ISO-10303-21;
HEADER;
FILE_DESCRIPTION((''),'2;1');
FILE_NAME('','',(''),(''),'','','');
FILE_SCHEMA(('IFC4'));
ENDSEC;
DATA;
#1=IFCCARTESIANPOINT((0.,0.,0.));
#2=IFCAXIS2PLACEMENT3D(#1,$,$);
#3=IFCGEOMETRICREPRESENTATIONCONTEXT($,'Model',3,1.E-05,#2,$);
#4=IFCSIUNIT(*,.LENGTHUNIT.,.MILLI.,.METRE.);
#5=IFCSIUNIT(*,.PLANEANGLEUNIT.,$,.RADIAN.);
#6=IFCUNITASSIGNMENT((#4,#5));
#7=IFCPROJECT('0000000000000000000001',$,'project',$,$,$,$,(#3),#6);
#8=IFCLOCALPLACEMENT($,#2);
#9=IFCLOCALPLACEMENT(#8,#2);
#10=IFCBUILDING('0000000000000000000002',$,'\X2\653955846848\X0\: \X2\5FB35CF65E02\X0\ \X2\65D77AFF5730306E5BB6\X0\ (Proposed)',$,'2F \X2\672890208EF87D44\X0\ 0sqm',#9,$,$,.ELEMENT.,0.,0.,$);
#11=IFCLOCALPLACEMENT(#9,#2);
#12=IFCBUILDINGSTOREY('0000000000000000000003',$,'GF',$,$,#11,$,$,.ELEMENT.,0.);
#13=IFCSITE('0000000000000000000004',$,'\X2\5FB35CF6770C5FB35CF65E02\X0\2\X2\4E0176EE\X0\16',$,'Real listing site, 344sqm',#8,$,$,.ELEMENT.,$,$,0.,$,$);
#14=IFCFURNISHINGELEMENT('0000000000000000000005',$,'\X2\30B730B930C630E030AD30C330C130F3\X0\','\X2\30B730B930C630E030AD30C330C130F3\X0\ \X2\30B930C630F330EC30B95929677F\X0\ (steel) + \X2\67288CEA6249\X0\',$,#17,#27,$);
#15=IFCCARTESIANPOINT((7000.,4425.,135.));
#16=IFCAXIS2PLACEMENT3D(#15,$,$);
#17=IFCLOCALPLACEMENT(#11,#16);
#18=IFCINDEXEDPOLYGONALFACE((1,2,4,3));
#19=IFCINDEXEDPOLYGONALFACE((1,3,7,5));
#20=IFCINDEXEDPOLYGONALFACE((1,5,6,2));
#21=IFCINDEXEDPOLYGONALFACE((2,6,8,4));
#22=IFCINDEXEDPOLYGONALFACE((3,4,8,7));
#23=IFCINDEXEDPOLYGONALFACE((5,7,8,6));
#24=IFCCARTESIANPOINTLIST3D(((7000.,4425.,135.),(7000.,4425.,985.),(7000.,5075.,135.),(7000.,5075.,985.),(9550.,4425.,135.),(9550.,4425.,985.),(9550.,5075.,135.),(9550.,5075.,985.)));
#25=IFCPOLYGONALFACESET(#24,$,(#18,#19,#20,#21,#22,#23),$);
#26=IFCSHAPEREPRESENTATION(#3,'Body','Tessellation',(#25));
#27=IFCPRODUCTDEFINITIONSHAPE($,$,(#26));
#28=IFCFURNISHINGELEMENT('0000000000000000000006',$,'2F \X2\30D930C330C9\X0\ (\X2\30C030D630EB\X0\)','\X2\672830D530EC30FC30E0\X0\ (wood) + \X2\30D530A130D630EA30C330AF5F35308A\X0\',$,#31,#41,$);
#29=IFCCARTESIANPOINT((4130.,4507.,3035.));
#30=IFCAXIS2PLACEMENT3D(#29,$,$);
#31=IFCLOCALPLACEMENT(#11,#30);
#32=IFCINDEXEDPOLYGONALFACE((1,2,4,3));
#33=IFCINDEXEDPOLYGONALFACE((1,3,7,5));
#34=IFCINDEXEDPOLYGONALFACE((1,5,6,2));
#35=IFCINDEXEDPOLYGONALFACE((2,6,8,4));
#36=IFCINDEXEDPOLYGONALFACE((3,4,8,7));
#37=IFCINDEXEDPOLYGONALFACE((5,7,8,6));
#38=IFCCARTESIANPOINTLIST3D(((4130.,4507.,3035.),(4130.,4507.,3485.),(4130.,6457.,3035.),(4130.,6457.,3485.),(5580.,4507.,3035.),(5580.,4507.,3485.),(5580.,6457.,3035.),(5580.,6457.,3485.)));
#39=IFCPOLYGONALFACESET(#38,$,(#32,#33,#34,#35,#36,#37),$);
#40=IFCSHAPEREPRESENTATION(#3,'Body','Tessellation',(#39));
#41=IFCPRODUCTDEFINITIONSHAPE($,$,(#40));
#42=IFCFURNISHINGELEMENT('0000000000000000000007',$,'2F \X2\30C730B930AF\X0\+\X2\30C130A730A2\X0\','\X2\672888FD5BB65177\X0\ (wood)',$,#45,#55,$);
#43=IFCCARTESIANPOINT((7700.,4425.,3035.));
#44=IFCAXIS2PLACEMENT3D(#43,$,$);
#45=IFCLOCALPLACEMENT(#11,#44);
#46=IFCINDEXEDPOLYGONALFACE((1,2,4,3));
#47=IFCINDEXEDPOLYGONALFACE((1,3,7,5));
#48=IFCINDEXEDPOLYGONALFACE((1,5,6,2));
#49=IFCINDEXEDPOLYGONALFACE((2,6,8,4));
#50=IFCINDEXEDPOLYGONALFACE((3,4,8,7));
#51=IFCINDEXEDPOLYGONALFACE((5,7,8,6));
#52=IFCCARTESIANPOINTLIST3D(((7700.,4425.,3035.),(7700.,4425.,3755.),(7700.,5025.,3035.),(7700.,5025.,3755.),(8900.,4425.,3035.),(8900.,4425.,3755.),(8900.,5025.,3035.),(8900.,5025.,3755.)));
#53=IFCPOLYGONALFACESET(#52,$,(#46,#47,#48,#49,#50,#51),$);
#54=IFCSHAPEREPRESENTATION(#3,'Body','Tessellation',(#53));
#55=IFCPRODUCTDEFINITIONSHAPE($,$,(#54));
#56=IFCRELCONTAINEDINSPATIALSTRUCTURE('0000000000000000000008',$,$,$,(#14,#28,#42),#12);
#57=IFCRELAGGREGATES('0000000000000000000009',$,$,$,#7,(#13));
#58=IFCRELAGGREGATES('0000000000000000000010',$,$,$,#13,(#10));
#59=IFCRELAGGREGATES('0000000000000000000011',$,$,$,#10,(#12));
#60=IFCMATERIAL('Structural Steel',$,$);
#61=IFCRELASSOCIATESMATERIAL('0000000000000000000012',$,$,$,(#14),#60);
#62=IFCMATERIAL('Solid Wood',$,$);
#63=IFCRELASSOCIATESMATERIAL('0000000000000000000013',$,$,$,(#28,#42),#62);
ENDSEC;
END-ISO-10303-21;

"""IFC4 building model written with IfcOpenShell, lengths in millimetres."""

from ifc_helpers import new_model, si_unit, frame, frame_2d, origin, place, context, project, spatial, rectangle, extrude, material, element, save


model = new_model("IFC4")

# Units and contexts
model_context = context("Model", 3, precision=1e-05, world=origin())
ifc_project = project(units=[si_unit("LENGTHUNIT", "METRE", prefix="MILLI"), si_unit("PLANEANGLEUNIT", "RADIAN")], contexts=[model_context])

# Site, building, storey
site_placement = place(None, origin())
site = spatial("IfcSite", under=ifc_project, at=site_placement, Name="徳島県徳島市2丁目16", ObjectType="Real listing site, 344sqm", CompositionType="ELEMENT", RefElevation=0.0)
building_placement = place(site_placement, origin())
building = spatial("IfcBuilding", under=site, at=building_placement, Name="改善案: 徳島市 旗竿地の家 (Proposed)", ObjectType="2F 木造軸組 0sqm", CompositionType="ELEMENT", ElevationOfRefHeight=0.0, ElevationOfTerrain=0.0)
storey_placement = place(building_placement, origin())
storey = spatial("IfcBuildingStorey", under=building, at=storey_placement, Name="GF", CompositionType="ELEMENT", Elevation=0.0)

# Shared definitions
ifc_material_1 = material(Name="Solid Wood")

# Furnishing elements
ifc_material_2 = material(Name="Structural Steel")
furnishing_1_placement = place(storey_placement, frame((7000.0, 4425.0, 135.0)))
element("IfcFurnishingElement", 1, at=furnishing_1_placement, inside=storey, material=ifc_material_2, Name="システムキッチン", Description="システムキッチン ステンレス天板 (steel) + 木質扉", context=model_context, shape_type="SweptSolid", body=[
    extrude(rectangle(XDim=2550.0, YDim=650.0, at=frame_2d((1275.0, 325.0))), frame((7000.0, 4425.0, 135.0)), (0.0, 0.0, 1.0), 850.0),
])
furnishing_2_placement = place(storey_placement, frame((4130.0, 4507.0, 3035.0)))
element("IfcFurnishingElement", 2, at=furnishing_2_placement, inside=storey, material=ifc_material_1, Name="2F ベッド (ダブル)", Description="木フレーム (wood) + ファブリック張り", context=model_context, shape_type="SweptSolid", body=[
    extrude(rectangle(XDim=1450.0, YDim=1950.0, at=frame_2d((725.0, 975.0))), frame((4130.0, 4507.0, 3035.0)), (0.0, 0.0, 1.0), 450.0),
])
furnishing_3_placement = place(storey_placement, frame((7700.0, 4425.0, 3035.0)))
element("IfcFurnishingElement", 3, at=furnishing_3_placement, inside=storey, material=ifc_material_1, Name="2F デスク+チェア", Description="木製家具 (wood)", context=model_context, shape_type="SweptSolid", body=[
    extrude(rectangle(XDim=1200.0, YDim=600.0, at=frame_2d((600.0, 300.0))), frame((7700.0, 4425.0, 3035.0)), (0.0, 0.0, 1.0), 720.0),
])

save(model, "model.ifc")
